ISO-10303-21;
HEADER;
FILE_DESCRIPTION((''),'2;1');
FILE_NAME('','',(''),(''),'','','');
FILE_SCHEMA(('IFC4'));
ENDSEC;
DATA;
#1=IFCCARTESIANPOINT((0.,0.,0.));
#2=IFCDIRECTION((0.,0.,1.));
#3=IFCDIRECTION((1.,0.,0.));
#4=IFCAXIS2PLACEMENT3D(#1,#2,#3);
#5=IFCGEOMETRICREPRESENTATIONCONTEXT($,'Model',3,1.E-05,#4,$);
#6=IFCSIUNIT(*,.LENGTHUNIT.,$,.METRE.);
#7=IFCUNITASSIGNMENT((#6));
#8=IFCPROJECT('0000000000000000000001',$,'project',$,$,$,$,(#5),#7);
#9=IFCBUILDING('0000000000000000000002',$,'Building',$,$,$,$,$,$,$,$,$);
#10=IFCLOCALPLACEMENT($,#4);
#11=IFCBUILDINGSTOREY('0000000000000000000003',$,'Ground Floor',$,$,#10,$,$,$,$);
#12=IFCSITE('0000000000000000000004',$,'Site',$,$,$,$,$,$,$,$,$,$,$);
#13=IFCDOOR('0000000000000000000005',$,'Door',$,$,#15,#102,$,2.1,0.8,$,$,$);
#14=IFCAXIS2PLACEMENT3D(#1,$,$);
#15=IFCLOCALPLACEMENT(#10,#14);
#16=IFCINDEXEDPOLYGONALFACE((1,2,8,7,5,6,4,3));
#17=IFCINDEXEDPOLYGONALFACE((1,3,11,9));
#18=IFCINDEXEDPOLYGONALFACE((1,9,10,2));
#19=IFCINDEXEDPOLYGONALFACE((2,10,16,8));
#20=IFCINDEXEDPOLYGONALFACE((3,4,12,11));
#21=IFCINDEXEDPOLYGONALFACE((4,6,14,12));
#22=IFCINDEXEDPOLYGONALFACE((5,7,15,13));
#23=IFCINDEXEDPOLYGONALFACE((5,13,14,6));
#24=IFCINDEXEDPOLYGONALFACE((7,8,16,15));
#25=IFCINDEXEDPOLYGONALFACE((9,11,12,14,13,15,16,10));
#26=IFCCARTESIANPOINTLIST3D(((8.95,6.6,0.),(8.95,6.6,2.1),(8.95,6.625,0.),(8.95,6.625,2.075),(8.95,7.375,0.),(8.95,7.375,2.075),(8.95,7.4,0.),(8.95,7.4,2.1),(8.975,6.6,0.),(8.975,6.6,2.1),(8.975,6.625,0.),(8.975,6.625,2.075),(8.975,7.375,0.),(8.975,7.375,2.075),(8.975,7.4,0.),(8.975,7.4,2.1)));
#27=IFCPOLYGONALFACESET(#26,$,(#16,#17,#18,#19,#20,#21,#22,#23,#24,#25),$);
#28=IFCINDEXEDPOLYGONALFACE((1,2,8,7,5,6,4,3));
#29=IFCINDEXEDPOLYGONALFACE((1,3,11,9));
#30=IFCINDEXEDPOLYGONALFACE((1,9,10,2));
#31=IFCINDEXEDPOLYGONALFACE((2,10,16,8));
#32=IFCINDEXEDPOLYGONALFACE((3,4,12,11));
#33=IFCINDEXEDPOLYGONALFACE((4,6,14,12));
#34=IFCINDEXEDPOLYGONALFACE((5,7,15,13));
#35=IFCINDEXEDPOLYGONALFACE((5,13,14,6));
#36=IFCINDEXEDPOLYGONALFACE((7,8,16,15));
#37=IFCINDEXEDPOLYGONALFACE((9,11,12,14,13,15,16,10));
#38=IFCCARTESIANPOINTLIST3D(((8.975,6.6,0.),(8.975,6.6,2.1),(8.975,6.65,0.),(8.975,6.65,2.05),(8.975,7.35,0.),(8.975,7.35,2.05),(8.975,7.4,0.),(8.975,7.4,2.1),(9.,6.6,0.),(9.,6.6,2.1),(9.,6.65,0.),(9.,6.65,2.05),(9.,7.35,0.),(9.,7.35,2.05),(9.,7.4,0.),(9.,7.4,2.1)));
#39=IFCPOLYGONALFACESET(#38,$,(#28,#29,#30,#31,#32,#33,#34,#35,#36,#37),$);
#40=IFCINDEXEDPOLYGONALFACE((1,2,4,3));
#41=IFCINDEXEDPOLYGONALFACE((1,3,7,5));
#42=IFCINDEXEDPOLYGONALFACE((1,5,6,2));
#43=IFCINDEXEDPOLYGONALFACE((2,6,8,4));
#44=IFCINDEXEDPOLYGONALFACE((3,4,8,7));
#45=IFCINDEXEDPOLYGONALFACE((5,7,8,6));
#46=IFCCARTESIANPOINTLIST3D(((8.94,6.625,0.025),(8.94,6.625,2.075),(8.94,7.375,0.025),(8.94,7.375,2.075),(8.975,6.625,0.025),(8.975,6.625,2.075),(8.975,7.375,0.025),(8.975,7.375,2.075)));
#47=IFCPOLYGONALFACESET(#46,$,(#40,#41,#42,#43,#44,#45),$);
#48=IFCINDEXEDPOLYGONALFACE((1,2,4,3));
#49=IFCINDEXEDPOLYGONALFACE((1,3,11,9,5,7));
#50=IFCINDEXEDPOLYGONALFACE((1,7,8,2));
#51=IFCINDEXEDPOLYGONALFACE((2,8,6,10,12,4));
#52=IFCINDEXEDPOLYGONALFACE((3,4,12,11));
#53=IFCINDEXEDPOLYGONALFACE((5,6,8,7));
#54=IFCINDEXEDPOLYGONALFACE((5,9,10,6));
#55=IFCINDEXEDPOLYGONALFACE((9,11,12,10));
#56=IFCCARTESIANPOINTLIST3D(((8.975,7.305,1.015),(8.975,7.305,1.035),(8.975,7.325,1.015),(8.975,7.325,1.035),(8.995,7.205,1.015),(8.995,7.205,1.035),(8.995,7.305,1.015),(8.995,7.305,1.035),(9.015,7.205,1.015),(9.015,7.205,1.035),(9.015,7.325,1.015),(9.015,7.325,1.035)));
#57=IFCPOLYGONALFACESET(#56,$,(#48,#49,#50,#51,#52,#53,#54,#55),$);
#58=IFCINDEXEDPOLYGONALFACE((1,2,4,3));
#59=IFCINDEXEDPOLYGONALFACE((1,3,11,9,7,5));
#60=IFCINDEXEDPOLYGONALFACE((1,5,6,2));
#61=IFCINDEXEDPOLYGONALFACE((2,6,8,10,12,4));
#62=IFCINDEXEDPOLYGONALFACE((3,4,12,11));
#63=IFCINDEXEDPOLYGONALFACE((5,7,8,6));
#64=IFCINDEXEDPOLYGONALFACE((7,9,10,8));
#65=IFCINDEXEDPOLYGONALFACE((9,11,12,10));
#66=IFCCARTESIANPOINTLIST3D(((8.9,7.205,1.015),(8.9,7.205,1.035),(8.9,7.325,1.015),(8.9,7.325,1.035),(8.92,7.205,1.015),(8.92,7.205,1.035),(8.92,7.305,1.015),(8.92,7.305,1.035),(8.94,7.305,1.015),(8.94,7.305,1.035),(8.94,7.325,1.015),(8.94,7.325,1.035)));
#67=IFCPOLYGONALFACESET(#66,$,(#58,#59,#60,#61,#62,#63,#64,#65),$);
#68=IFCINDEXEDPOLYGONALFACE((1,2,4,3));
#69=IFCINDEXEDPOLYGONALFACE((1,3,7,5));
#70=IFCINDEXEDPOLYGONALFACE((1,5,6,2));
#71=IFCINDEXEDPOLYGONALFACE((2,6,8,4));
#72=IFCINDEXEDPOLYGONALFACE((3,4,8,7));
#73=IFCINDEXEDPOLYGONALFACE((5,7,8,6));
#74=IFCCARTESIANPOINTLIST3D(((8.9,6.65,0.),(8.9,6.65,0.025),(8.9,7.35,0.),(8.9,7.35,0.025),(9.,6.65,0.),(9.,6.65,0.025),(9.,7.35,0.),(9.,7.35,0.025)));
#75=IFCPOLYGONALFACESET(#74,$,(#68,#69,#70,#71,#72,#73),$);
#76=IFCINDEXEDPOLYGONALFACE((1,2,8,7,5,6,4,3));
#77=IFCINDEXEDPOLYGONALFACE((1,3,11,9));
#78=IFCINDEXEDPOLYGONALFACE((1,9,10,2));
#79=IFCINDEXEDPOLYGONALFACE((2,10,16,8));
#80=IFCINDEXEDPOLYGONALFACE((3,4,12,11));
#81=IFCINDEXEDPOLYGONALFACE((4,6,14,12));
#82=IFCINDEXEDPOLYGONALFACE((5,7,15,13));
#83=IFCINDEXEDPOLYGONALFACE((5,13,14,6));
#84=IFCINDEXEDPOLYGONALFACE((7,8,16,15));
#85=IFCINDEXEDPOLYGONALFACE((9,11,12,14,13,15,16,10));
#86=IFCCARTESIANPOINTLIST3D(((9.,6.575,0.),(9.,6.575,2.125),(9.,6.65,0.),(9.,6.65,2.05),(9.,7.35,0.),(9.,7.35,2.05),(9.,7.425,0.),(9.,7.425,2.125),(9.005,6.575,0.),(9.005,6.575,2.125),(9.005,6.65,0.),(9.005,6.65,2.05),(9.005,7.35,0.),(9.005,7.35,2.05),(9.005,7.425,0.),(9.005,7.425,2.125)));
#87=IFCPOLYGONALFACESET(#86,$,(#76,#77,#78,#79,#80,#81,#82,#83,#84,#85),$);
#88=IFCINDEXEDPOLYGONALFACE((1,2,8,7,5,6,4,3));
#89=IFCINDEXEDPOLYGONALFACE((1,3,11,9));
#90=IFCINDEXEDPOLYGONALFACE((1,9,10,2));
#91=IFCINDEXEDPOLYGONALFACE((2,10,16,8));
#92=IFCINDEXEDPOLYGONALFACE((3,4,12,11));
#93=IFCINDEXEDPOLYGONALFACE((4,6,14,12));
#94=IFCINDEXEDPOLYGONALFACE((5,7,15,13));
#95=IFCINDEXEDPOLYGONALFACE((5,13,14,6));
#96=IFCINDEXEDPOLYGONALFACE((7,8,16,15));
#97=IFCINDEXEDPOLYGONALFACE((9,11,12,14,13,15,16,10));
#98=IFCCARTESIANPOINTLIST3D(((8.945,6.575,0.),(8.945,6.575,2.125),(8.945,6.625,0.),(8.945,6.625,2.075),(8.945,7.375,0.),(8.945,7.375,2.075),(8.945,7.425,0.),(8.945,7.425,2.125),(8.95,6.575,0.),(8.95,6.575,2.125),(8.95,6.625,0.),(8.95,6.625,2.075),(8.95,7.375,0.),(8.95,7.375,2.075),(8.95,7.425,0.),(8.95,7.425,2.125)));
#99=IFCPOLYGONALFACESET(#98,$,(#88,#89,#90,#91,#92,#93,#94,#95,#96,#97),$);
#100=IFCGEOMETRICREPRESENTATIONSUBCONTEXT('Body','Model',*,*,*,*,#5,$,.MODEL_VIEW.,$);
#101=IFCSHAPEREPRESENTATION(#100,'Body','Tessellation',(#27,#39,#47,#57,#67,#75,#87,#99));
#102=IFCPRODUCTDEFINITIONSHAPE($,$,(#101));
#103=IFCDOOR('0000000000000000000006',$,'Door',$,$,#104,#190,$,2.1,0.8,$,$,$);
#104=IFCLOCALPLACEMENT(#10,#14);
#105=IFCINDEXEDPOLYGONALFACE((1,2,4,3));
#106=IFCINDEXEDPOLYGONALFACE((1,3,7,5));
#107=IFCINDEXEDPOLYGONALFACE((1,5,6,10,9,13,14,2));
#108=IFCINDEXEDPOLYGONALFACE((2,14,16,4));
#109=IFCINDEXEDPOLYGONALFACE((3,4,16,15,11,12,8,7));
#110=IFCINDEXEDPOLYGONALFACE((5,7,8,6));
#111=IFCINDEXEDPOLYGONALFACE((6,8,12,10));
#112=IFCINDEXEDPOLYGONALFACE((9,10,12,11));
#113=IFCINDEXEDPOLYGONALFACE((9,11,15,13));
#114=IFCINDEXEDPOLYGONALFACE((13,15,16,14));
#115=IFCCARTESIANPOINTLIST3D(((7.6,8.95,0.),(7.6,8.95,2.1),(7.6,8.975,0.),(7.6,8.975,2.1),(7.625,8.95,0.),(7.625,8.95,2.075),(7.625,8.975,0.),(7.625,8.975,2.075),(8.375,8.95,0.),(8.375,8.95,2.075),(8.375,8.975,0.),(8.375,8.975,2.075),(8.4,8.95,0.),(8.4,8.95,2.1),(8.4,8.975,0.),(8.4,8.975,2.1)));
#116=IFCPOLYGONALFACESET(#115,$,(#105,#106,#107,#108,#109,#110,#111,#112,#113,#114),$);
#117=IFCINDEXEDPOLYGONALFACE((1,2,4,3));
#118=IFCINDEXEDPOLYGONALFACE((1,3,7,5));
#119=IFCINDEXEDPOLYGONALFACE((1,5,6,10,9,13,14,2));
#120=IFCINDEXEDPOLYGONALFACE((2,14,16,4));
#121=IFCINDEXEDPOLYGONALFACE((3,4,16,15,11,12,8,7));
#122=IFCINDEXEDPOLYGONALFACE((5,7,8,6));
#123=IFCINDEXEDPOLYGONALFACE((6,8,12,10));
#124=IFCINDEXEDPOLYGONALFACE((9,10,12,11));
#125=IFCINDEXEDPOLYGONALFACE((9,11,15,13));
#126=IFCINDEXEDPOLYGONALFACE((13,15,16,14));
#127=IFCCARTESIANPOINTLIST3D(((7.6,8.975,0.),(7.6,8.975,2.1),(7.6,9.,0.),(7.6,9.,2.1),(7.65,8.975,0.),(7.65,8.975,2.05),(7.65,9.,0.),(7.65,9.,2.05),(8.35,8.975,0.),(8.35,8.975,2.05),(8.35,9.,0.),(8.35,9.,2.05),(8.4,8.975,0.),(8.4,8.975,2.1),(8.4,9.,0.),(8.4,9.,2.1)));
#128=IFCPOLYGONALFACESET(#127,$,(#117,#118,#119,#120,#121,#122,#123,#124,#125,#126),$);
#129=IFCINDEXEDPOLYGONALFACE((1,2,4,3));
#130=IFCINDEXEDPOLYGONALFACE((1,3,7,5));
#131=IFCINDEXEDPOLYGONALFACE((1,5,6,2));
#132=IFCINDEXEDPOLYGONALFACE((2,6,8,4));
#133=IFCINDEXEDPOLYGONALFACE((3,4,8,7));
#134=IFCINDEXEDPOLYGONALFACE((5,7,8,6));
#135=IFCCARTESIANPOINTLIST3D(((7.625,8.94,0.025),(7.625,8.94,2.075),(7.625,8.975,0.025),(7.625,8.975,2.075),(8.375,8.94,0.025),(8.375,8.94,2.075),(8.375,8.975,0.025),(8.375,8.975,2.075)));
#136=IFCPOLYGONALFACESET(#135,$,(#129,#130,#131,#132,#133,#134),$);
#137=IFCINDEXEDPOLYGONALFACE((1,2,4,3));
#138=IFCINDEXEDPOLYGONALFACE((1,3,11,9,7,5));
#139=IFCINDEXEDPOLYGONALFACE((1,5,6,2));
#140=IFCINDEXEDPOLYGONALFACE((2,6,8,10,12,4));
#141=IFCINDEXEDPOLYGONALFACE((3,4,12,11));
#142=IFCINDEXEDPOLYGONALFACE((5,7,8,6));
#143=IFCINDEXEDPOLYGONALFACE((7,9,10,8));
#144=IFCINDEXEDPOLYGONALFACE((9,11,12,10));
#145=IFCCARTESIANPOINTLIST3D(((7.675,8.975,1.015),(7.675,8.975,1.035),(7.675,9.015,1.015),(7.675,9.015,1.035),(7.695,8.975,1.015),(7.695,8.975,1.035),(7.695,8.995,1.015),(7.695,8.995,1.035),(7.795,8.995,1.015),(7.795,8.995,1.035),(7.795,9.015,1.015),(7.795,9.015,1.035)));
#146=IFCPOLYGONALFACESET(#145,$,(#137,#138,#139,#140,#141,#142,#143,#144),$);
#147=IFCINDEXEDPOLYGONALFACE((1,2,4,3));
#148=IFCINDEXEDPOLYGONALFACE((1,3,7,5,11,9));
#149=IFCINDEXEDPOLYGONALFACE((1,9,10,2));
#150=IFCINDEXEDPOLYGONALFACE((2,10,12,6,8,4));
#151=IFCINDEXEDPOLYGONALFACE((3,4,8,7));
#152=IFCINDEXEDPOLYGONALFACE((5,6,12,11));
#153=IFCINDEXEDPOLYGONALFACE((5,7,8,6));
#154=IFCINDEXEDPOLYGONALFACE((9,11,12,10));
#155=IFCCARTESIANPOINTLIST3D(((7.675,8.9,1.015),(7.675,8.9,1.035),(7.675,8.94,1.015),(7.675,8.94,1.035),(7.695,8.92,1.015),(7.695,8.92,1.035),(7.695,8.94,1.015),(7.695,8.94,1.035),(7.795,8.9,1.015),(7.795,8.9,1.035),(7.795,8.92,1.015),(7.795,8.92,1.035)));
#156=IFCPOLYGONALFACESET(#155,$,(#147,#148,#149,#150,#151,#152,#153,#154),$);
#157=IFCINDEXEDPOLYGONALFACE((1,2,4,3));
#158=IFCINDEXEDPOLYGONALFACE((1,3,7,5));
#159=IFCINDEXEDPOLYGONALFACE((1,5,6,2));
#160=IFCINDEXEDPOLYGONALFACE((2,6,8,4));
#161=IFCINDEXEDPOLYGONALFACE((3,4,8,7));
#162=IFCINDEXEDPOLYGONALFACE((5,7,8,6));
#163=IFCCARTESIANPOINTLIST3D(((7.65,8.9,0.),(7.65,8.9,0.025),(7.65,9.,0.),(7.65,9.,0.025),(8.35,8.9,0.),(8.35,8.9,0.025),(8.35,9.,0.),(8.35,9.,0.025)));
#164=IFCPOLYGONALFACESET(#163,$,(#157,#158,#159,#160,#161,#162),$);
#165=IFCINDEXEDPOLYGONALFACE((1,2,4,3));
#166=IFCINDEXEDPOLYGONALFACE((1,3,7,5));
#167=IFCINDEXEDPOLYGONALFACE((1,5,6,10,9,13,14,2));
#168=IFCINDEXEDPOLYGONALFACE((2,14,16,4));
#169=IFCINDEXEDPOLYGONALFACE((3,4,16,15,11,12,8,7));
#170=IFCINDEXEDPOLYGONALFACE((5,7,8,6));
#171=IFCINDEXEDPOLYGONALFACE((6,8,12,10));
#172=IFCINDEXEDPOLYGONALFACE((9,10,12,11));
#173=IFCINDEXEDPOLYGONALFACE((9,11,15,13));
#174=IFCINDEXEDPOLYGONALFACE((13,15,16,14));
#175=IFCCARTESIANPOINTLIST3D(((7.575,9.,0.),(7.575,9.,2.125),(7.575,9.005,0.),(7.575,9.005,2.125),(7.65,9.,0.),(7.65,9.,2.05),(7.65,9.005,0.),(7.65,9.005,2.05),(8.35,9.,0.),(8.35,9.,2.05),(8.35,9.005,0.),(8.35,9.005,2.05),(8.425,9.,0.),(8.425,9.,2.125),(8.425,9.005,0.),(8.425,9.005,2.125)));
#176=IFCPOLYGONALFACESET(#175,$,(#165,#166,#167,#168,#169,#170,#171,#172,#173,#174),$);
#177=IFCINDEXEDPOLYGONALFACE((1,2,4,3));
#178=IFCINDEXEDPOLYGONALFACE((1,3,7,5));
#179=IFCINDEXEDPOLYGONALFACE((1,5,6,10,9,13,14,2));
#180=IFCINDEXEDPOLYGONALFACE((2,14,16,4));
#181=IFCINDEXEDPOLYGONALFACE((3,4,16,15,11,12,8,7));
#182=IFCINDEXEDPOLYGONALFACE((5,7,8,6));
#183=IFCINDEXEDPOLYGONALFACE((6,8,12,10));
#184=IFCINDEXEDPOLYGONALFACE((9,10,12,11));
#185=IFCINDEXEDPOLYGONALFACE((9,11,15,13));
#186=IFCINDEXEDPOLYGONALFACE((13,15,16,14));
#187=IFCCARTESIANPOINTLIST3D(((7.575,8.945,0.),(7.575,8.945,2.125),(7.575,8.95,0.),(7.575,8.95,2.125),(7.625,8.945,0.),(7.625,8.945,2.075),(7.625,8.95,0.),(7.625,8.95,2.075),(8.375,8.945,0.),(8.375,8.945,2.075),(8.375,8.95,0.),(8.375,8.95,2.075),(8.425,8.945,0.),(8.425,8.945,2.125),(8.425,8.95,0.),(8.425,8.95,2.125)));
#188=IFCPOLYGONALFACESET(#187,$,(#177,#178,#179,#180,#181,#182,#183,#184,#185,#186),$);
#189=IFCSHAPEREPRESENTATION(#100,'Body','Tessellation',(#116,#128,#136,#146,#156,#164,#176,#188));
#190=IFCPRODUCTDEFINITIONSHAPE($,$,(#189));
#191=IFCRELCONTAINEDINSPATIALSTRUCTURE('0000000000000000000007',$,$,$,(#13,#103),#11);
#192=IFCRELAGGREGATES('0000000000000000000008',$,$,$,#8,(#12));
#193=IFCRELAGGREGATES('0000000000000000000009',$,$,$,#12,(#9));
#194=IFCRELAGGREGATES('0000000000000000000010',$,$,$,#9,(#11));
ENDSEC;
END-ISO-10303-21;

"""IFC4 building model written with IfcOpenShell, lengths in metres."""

from ifc_helpers import new_model, si_unit, frame, origin_with_axes, place, context, subcontext, project, spatial, line, indexed_curve, outline, extrude, element, save


model = new_model("IFC4")

# Units and contexts
model_context = context("Model", 3, precision=1e-05, world=origin_with_axes())
body_context = subcontext(model_context, "Body", "Model", "MODEL_VIEW")
ifc_project = project(units=[si_unit("LENGTHUNIT", "METRE")], contexts=[model_context])

# Site, building, storey
site = spatial("IfcSite", under=ifc_project, Name="Site")
building = spatial("IfcBuilding", under=site, Name="Building")
storey_placement = place(None, origin_with_axes())
storey = spatial("IfcBuildingStorey", under=building, at=storey_placement, Name="Ground Floor")

# Doors
door_1_placement = place(storey_placement, frame((9.0, 6.6, 0.0), z_axis=(0.0, 0.0, 1.0), x_axis=(0.0, 1.0, 0.0)))
element("IfcDoor", 1, at=door_1_placement, inside=storey, Name="Door", OverallHeight=2.1, OverallWidth=0.8, context=body_context, shape_type="SweptSolid", body=[
    extrude(outline(indexed_curve([(0.0, 0.0), (0.0, 2.1), (0.8, 2.1), (0.8, 0.0), (0.775, 0.0), (0.775, 2.075), (0.025, 2.075), (0.025, 0.0)], segments=[line(1, 2, 3, 4, 5, 6, 7, 8, 1)])), frame((0.0, 0.025, 0.0), z_axis=(0.0, -1.0, 0.0), x_axis=(1.0, 0.0, 0.0)), (0.0, 0.0, -1.0), 0.025),
    extrude(outline(indexed_curve([(0.0, 0.0), (0.0, 2.1), (0.8, 2.1), (0.8, 0.0), (0.75, 0.0), (0.75, 2.05), (0.05, 2.05), (0.05, 0.0)], segments=[line(1, 2, 3, 4, 5, 6, 7, 8, 1)])), frame((0.0, 0.0, 0.0), z_axis=(0.0, -1.0, 0.0), x_axis=(1.0, 0.0, 0.0)), (0.0, 0.0, -1.0), 0.025),
    extrude(outline(indexed_curve([(0.0, 0.0), (0.75, 0.0), (0.75, 0.035), (0.0, 0.035)], segments=[line(1, 2, 3, 4, 1)])), frame((0.025, 0.025, 0.025), z_axis=(0.0, 0.0, 1.0), x_axis=(1.0, 0.0, 0.0)), (0.0, 0.0, 1.0), 2.05),
    extrude(outline(indexed_curve([(0.0, 0.0), (0.0, -0.04), (-0.12, -0.04), (-0.12, -0.02), (-0.02, -0.02), (-0.02, 0.0)], segments=[line(1, 2, 3, 4, 5, 6, 1)])), frame((0.725, 0.025, 1.015), z_axis=(0.0, 0.0, 1.0), x_axis=(1.0, 0.0, 0.0)), (0.0, 0.0, 1.0), 0.02),
    extrude(outline(indexed_curve([(0.0, 0.0), (0.0, 0.04), (-0.12, 0.04), (-0.12, 0.02), (-0.02, 0.02), (-0.02, 0.0)], segments=[line(1, 2, 3, 4, 5, 6, 1)])), frame((0.725, 0.06, 1.015), z_axis=(0.0, 0.0, 1.0), x_axis=(1.0, 0.0, 0.0)), (0.0, 0.0, 1.0), 0.02),
    extrude(outline(indexed_curve([(0.0, 0.0), (0.7, 0.0), (0.7, 0.1), (0.0, 0.1)], segments=[line(1, 2, 3, 4, 1)])), frame((0.05, 0.0, 0.0), z_axis=(0.0, 0.0, 1.0), x_axis=(1.0, 0.0, 0.0)), (0.0, 0.0, 1.0), 0.025),
    extrude(outline(indexed_curve([(0.0, 0.0), (0.0, 2.125), (0.85, 2.125), (0.85, 0.0), (0.775, 0.0), (0.775, 2.05), (0.075, 2.05), (0.075, 0.0)], segments=[line(1, 2, 3, 4, 5, 6, 7, 8, 1)])), frame((-0.025, -0.005, 0.0), z_axis=(0.0, -1.0, 0.0), x_axis=(1.0, 0.0, 0.0)), (0.0, 0.0, -1.0), 0.005),
    extrude(outline(indexed_curve([(0.0, 0.0), (0.0, 2.125), (0.85, 2.125), (0.85, 0.0), (0.8, 0.0), (0.8, 2.075), (0.05, 2.075), (0.05, 0.0)], segments=[line(1, 2, 3, 4, 5, 6, 7, 8, 1)])), frame((-0.025, 0.05, 0.0), z_axis=(0.0, -1.0, 0.0), x_axis=(1.0, 0.0, 0.0)), (0.0, 0.0, -1.0), 0.005),
])
door_2_placement = place(storey_placement, frame((8.4, 9.0, 0.0), z_axis=(0.0, 0.0, 1.0), x_axis=(-1.0, 0.0, 0.0)))
element("IfcDoor", 2, at=door_2_placement, inside=storey, Name="Door", OverallHeight=2.1, OverallWidth=0.8, context=body_context, shape_type="SweptSolid", body=[
    extrude(outline(indexed_curve([(0.0, 0.0), (0.0, 2.1), (0.8, 2.1), (0.8, 0.0), (0.775, 0.0), (0.775, 2.075), (0.025, 2.075), (0.025, 0.0)], segments=[line(1, 2, 3, 4, 5, 6, 7, 8, 1)])), frame((0.0, 0.025, 0.0), z_axis=(0.0, -1.0, 0.0), x_axis=(1.0, 0.0, 0.0)), (0.0, 0.0, -1.0), 0.025),
    extrude(outline(indexed_curve([(0.0, 0.0), (0.0, 2.1), (0.8, 2.1), (0.8, 0.0), (0.75, 0.0), (0.75, 2.05), (0.05, 2.05), (0.05, 0.0)], segments=[line(1, 2, 3, 4, 5, 6, 7, 8, 1)])), frame((0.0, 0.0, 0.0), z_axis=(0.0, -1.0, 0.0), x_axis=(1.0, 0.0, 0.0)), (0.0, 0.0, -1.0), 0.025),
    extrude(outline(indexed_curve([(0.0, 0.0), (0.75, 0.0), (0.75, 0.035), (0.0, 0.035)], segments=[line(1, 2, 3, 4, 1)])), frame((0.025, 0.025, 0.025), z_axis=(0.0, 0.0, 1.0), x_axis=(1.0, 0.0, 0.0)), (0.0, 0.0, 1.0), 2.05),
    extrude(outline(indexed_curve([(0.0, 0.0), (0.0, -0.04), (-0.12, -0.04), (-0.12, -0.02), (-0.02, -0.02), (-0.02, 0.0)], segments=[line(1, 2, 3, 4, 5, 6, 1)])), frame((0.725, 0.025, 1.015), z_axis=(0.0, 0.0, 1.0), x_axis=(1.0, 0.0, 0.0)), (0.0, 0.0, 1.0), 0.02),
    extrude(outline(indexed_curve([(0.0, 0.0), (0.0, 0.04), (-0.12, 0.04), (-0.12, 0.02), (-0.02, 0.02), (-0.02, 0.0)], segments=[line(1, 2, 3, 4, 5, 6, 1)])), frame((0.725, 0.06, 1.015), z_axis=(0.0, 0.0, 1.0), x_axis=(1.0, 0.0, 0.0)), (0.0, 0.0, 1.0), 0.02),
    extrude(outline(indexed_curve([(0.0, 0.0), (0.7, 0.0), (0.7, 0.1), (0.0, 0.1)], segments=[line(1, 2, 3, 4, 1)])), frame((0.05, 0.0, 0.0), z_axis=(0.0, 0.0, 1.0), x_axis=(1.0, 0.0, 0.0)), (0.0, 0.0, 1.0), 0.025),
    extrude(outline(indexed_curve([(0.0, 0.0), (0.0, 2.125), (0.85, 2.125), (0.85, 0.0), (0.775, 0.0), (0.775, 2.05), (0.075, 2.05), (0.075, 0.0)], segments=[line(1, 2, 3, 4, 5, 6, 7, 8, 1)])), frame((-0.025, -0.005, 0.0), z_axis=(0.0, -1.0, 0.0), x_axis=(1.0, 0.0, 0.0)), (0.0, 0.0, -1.0), 0.005),
    extrude(outline(indexed_curve([(0.0, 0.0), (0.0, 2.125), (0.85, 2.125), (0.85, 0.0), (0.8, 0.0), (0.8, 2.075), (0.05, 2.075), (0.05, 0.0)], segments=[line(1, 2, 3, 4, 5, 6, 7, 8, 1)])), frame((-0.025, 0.05, 0.0), z_axis=(0.0, -1.0, 0.0), x_axis=(1.0, 0.0, 0.0)), (0.0, 0.0, -1.0), 0.005),
])

save(model, "model.ifc")
